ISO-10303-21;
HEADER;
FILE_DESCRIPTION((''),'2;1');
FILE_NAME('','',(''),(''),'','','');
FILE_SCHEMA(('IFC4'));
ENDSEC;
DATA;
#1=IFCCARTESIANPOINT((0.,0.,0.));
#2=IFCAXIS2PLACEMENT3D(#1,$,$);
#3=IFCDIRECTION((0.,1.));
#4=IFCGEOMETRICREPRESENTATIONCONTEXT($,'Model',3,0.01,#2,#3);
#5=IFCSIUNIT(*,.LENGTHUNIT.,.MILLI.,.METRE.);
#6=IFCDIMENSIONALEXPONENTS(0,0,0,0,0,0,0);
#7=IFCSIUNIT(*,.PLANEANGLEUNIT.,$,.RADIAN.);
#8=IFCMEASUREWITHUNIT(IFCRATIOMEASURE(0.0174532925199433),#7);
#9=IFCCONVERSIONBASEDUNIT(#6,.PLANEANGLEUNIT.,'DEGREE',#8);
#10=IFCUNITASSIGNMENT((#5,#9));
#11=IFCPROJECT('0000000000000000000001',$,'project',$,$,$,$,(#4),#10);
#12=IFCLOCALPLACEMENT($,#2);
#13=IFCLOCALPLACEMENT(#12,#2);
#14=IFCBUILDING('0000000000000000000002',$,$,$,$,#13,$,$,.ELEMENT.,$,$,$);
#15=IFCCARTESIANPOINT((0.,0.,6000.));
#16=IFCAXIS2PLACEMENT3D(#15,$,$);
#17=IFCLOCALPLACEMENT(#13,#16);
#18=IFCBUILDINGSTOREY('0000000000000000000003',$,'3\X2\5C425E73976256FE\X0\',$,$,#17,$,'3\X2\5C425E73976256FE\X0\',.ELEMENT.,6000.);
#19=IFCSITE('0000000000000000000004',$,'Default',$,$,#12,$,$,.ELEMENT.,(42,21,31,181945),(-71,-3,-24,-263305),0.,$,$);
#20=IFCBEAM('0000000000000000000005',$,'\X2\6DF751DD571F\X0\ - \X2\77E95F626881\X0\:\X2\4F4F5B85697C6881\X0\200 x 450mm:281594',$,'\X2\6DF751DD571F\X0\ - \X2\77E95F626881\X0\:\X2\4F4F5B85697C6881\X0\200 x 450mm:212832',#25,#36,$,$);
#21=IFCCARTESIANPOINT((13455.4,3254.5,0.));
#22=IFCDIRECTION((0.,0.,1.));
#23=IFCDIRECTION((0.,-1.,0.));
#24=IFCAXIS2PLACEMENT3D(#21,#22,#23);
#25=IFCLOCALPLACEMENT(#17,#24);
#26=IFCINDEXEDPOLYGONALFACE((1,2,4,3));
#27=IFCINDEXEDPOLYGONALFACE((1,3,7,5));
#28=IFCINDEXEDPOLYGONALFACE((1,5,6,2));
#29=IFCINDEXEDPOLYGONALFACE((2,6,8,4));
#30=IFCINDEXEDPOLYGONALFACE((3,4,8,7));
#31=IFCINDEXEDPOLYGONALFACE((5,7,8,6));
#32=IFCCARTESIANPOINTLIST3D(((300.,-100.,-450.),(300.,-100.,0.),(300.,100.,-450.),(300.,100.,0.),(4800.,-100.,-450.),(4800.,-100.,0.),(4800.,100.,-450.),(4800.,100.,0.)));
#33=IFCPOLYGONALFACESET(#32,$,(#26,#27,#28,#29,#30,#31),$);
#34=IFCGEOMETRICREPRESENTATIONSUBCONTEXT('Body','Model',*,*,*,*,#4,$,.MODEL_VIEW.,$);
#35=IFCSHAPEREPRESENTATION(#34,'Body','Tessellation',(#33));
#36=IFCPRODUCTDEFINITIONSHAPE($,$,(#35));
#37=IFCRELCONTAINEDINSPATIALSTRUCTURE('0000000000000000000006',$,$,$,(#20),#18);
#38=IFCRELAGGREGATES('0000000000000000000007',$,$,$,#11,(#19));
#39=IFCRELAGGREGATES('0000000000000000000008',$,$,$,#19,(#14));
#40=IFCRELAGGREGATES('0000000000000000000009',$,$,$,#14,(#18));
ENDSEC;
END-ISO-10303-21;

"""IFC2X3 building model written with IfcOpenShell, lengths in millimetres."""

from ifc_helpers import new_model, entity, si_unit, converted_unit, direction, frame, origin, origin_2d_with_axis, place, context, subcontext, project, spatial, rectangle, extrude, element, save


model = new_model("IFC2X3")

# Units and contexts
model_context = context("Model", 3, precision=0.01, world=origin(), true_north=direction((0.0, 1.0)))
body_context = subcontext(model_context, "Body", "Model", "MODEL_VIEW")
ifc_project = project(units=[si_unit("LENGTHUNIT", "METRE", prefix="MILLI"), converted_unit("PLANEANGLEUNIT", "DEGREE", entity("IfcRatioMeasure", 0.0174532925199433), si_unit("PLANEANGLEUNIT", "RADIAN"), dimensions=[0, 0, 0, 0, 0, 0, 0])], contexts=[model_context])

# Site, building, storey
site_placement = place(None, origin())
site = spatial("IfcSite", under=ifc_project, at=site_placement, Name="Default", CompositionType="ELEMENT", RefLatitude=(42, 21, 31, 181945), RefLongitude=(-71, -3, -24, -263305), RefElevation=0.0)
building_placement = place(site_placement, origin())
building = spatial("IfcBuilding", under=site, at=building_placement, CompositionType="ELEMENT")
storey_placement = place(building_placement, frame((0.0, 0.0, 6000.0)))
storey = spatial("IfcBuildingStorey", under=building, at=storey_placement, Name="3层平面图", LongName="3层平面图", CompositionType="ELEMENT", Elevation=6000.0)

# Beam
beam_1_placement = place(storey_placement, frame((13455.4, 3254.5, 0.0), z_axis=(0.0, 0.0, 1.0), x_axis=(0.0, -1.0, 0.0)))
element("IfcBeam", 1, at=beam_1_placement, inside=storey, Name="混凝土 - 矩形梁:住宅楼梁200 x 450mm:281594", ObjectType="混凝土 - 矩形梁:住宅楼梁200 x 450mm:212832", context=body_context, shape_type="SweptSolid", body=[
    extrude(rectangle(XDim=450.0, YDim=200.0, at=origin_2d_with_axis()), frame((300.0, 0.0, -225.0), z_axis=(1.0, 0.0, 0.0), x_axis=(0.0, 0.0, -1.0)), (0.0, 0.0, 1.0), 4500.0),
])

save(model, "model.ifc")
